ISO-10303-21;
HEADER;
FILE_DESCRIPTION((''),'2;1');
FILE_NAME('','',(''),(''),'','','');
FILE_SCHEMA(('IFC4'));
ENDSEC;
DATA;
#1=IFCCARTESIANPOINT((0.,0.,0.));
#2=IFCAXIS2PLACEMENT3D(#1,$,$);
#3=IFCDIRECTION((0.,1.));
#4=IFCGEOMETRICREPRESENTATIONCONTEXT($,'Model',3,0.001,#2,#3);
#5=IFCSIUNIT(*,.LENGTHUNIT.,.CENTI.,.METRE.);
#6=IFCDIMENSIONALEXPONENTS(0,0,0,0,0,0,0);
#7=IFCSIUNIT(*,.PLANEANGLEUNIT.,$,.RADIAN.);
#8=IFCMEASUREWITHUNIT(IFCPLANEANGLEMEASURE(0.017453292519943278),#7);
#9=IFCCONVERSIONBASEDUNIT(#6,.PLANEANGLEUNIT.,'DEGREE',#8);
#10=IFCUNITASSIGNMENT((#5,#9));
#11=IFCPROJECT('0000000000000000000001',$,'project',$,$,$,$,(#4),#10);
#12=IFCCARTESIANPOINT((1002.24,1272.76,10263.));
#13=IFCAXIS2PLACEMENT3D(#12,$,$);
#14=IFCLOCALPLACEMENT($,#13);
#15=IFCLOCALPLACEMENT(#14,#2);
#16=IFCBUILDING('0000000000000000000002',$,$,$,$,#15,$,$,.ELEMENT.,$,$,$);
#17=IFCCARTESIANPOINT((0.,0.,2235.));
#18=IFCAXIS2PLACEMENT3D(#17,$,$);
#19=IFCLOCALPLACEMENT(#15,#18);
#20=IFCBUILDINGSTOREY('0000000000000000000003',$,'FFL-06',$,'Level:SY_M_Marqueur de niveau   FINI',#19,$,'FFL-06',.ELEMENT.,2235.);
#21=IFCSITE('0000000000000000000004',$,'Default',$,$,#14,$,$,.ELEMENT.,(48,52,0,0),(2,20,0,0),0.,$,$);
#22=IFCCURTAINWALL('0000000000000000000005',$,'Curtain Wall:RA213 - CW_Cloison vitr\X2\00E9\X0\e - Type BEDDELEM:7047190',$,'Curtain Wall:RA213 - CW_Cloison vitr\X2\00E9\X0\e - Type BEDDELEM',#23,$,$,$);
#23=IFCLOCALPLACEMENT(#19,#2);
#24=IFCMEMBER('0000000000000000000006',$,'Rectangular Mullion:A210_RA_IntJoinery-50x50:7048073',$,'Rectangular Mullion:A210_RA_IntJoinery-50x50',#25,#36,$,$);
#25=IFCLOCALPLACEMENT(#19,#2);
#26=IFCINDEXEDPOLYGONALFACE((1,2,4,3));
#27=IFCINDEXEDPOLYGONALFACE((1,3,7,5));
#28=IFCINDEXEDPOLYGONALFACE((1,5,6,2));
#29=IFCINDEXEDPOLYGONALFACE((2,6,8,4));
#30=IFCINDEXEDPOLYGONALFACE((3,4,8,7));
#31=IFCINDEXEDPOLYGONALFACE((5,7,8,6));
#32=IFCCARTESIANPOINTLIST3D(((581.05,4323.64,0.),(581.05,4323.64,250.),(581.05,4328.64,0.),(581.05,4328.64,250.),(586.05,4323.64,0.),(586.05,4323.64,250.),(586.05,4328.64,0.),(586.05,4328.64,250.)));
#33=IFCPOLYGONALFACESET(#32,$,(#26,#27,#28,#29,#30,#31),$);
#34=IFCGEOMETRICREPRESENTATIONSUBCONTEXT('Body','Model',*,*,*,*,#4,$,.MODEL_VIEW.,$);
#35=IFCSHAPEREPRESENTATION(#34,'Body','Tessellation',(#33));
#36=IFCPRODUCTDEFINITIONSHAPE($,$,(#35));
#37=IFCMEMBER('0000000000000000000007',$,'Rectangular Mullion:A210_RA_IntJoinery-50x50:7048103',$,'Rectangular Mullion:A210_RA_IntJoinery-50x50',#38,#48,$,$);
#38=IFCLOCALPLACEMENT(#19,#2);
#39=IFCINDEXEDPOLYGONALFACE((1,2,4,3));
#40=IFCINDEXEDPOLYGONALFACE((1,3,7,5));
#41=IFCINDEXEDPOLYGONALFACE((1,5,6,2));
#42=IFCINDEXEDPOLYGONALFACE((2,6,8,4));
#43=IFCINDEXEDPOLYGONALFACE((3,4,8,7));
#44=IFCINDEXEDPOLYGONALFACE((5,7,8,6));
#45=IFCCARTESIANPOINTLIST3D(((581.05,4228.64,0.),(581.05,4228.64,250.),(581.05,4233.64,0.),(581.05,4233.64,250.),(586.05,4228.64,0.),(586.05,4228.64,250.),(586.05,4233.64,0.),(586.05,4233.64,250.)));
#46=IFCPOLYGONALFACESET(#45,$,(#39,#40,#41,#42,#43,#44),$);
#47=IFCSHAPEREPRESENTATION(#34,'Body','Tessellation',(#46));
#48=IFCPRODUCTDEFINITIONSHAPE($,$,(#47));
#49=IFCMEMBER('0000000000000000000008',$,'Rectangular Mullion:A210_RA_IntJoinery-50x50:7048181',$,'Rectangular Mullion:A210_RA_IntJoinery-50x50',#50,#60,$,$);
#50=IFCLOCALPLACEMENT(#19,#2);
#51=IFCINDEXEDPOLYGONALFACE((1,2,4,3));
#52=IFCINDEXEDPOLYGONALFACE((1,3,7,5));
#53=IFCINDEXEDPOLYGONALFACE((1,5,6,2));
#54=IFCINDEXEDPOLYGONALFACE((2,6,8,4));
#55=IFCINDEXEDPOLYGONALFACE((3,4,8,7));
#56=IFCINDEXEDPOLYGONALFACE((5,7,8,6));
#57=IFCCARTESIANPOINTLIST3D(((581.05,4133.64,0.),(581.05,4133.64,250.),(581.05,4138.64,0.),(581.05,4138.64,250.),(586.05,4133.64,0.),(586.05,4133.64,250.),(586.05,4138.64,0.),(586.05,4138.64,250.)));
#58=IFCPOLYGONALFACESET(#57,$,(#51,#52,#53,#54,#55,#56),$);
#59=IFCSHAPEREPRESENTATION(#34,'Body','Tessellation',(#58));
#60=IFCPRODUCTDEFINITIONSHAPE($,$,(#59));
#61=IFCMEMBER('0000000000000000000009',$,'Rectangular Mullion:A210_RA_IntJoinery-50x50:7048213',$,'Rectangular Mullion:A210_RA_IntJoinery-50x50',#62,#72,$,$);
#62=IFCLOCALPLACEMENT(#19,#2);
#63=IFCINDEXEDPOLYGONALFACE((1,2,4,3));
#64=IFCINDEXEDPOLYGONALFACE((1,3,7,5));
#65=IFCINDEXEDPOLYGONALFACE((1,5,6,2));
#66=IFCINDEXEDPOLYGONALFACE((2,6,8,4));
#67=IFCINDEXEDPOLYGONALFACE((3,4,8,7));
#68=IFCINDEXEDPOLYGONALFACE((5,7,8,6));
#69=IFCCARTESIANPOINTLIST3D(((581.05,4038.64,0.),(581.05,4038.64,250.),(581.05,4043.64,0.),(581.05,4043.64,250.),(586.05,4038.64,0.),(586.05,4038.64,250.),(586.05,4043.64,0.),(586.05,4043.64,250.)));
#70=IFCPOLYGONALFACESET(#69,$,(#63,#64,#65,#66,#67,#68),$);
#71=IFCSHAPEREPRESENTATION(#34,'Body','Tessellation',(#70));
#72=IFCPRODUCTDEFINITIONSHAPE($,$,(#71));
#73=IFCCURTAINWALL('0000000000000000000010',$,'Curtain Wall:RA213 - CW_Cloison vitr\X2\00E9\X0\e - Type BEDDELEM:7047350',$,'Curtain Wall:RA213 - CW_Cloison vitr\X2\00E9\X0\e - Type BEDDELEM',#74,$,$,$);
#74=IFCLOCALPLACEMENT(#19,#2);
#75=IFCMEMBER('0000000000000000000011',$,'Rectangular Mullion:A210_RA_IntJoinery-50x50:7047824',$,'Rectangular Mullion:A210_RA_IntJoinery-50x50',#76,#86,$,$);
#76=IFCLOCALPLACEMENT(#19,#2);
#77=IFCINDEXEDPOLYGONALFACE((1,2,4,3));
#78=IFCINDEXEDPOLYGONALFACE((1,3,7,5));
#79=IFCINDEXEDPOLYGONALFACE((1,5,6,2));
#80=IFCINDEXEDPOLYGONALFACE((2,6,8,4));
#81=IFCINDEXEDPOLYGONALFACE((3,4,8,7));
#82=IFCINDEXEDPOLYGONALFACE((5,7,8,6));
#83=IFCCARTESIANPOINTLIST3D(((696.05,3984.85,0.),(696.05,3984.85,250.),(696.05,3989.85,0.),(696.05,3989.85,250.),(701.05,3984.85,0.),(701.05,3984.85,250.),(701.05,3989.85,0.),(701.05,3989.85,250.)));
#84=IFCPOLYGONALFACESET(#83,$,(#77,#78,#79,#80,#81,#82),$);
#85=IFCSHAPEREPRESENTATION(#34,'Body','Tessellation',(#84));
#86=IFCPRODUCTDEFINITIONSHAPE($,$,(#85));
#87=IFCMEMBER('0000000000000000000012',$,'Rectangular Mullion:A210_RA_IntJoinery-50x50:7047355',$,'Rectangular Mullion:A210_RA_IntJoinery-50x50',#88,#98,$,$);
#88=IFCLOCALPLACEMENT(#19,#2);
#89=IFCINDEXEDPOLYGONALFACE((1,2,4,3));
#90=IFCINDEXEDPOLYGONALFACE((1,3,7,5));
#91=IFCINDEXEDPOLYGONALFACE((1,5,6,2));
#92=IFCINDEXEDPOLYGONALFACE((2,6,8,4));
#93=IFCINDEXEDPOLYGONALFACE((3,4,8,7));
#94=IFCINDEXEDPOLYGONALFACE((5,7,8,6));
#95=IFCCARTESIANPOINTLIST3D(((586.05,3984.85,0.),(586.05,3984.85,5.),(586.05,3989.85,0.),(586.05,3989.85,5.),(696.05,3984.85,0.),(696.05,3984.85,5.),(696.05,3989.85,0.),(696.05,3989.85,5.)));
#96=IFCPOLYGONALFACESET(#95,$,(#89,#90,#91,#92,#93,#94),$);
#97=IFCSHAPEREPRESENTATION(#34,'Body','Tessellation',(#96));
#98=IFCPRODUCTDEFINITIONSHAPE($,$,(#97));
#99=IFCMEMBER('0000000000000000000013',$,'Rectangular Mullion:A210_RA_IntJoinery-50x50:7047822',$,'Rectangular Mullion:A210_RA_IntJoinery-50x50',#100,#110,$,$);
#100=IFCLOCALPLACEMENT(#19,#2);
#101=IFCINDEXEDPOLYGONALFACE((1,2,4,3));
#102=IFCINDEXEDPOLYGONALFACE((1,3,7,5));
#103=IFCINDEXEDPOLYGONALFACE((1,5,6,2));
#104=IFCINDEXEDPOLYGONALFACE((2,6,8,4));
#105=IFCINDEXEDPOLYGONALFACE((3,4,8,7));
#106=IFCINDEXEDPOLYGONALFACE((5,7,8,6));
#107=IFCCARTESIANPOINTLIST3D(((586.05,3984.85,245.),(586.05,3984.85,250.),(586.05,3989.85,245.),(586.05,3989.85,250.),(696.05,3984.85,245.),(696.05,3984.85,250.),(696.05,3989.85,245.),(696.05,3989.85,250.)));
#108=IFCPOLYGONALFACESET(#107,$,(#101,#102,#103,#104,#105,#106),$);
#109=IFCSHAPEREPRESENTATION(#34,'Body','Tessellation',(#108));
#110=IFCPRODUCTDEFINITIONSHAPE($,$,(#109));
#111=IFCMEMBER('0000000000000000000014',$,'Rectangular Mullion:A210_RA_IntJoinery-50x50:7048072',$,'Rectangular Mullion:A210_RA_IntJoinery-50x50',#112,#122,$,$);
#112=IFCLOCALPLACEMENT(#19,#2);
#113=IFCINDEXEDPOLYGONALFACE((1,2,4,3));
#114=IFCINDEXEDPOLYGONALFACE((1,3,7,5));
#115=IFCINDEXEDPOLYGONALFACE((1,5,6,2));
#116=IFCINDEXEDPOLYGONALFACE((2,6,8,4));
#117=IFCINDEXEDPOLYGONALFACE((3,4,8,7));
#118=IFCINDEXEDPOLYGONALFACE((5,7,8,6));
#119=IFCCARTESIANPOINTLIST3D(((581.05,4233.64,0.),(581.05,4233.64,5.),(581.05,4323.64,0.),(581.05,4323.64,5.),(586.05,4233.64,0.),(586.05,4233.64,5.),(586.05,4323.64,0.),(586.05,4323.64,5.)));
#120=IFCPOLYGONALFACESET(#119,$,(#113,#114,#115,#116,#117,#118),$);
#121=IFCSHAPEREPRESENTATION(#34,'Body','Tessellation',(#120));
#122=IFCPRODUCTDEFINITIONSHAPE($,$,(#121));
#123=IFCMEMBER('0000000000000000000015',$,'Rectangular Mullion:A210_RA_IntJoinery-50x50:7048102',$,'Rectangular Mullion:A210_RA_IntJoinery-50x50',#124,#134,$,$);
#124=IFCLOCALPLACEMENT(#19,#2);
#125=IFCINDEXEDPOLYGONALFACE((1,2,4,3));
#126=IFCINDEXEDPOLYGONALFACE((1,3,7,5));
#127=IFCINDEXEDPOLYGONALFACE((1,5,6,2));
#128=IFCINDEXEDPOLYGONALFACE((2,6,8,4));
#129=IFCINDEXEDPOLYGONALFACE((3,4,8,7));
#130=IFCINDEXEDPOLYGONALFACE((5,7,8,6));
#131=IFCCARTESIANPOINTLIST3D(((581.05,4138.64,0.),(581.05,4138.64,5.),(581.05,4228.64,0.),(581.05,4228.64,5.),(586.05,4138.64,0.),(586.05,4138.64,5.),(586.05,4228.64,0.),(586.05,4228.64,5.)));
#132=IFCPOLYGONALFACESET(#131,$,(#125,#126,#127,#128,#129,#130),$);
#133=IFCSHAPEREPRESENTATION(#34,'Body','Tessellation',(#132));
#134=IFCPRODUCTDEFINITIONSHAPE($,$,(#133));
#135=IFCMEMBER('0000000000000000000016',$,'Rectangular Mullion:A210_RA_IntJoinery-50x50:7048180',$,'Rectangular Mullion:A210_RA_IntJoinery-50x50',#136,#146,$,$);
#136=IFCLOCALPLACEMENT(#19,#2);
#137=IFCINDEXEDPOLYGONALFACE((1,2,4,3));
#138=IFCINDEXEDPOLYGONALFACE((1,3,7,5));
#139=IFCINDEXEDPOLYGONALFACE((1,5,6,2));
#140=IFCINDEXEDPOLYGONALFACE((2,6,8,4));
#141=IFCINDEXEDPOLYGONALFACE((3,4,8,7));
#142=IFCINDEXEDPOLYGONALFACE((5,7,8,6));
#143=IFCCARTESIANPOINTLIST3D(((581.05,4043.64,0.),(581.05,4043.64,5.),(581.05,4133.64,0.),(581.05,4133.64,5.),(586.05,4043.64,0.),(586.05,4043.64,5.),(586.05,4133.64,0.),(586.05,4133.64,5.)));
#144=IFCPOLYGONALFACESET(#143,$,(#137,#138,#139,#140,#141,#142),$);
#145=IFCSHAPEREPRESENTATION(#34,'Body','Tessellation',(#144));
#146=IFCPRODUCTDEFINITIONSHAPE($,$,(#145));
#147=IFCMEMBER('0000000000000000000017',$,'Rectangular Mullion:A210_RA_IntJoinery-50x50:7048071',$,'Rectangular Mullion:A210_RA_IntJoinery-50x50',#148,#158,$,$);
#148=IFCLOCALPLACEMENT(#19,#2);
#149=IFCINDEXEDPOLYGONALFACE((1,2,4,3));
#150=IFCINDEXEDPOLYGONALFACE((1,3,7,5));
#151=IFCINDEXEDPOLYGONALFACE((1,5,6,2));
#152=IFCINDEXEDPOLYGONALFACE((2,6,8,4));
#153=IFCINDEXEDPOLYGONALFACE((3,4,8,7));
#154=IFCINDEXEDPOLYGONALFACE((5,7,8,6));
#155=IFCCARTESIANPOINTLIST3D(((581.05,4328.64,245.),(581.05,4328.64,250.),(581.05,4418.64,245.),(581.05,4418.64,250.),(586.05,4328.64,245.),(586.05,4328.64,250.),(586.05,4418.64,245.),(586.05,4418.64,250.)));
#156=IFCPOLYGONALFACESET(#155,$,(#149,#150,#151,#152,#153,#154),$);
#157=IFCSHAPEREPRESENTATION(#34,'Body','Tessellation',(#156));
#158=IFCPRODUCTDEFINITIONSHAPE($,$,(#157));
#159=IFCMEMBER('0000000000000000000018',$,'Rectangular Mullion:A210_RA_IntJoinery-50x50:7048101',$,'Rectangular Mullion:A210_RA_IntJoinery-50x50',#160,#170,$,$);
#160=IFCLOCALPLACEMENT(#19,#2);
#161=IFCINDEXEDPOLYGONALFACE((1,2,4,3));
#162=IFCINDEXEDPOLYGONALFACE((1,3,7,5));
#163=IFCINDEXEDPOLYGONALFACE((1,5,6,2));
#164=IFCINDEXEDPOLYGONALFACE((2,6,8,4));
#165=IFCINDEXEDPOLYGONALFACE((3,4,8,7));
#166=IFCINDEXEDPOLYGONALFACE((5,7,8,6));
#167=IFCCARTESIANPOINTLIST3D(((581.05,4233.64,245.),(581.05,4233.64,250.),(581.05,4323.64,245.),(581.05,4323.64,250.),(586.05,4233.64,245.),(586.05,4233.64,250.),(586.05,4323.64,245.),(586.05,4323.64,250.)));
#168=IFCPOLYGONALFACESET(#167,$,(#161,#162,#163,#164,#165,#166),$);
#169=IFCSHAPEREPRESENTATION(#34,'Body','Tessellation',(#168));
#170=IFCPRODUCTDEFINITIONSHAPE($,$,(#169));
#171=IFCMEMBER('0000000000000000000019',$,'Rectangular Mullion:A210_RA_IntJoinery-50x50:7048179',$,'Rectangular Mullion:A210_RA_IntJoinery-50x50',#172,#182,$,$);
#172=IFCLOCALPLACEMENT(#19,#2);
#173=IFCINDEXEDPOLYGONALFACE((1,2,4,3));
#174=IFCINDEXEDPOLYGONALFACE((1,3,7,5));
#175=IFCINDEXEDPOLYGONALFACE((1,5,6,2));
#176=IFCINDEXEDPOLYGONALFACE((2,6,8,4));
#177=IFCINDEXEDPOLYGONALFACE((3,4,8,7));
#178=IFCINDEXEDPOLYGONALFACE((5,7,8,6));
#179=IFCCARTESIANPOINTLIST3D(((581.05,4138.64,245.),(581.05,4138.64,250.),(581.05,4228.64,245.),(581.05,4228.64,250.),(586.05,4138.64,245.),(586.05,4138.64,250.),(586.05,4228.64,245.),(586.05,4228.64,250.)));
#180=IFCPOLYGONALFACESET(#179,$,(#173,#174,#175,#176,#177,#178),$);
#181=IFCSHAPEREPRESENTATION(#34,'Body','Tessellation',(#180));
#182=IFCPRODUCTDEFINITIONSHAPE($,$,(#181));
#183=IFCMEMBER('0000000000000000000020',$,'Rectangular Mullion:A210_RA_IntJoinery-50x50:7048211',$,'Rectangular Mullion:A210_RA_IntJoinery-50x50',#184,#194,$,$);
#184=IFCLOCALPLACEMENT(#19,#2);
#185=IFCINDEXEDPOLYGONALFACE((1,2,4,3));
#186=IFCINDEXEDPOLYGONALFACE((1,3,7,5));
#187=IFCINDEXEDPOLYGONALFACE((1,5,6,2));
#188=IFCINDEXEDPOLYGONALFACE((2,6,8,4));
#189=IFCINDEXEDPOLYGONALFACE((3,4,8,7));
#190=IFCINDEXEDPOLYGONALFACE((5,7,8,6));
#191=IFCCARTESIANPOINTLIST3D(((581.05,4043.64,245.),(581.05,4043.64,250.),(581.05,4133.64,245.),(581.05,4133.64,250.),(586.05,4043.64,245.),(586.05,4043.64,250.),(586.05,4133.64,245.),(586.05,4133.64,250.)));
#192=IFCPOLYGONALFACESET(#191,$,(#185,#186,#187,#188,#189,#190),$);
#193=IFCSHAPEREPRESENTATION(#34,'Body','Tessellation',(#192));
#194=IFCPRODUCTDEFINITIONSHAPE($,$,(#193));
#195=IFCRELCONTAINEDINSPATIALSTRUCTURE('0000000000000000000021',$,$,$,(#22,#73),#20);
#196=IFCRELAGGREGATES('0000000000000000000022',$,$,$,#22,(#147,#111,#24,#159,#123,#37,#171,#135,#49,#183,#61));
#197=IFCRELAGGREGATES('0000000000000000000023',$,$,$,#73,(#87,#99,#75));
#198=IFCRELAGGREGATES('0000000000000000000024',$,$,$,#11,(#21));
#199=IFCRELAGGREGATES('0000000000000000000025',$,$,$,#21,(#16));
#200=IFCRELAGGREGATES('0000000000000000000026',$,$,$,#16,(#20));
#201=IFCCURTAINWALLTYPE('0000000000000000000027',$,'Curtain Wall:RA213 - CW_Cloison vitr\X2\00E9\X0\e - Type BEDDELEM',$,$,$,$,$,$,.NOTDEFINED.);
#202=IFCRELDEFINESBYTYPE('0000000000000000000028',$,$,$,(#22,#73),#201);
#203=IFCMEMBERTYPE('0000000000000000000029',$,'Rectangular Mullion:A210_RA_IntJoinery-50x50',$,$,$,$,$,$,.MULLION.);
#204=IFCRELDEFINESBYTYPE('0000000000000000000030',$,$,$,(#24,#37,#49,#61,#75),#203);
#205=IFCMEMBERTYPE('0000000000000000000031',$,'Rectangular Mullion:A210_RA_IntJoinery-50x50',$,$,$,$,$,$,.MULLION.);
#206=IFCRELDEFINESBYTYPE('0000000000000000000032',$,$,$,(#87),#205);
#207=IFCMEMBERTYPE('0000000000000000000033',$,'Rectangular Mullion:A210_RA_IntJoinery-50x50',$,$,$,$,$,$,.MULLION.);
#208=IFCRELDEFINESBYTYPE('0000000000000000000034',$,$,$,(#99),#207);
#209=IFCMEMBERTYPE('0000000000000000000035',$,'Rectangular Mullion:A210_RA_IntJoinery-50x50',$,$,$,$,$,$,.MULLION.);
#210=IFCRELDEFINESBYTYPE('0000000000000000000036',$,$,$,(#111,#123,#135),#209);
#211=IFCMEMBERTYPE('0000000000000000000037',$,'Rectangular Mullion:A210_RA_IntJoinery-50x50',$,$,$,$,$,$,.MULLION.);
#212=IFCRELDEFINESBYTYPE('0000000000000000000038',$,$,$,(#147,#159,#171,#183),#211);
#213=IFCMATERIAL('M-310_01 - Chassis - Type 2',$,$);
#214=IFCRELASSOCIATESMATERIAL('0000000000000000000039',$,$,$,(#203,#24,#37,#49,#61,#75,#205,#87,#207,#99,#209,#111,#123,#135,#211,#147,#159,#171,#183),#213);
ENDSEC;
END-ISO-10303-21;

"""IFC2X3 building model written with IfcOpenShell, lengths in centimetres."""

from ifc_helpers import new_model, entity, si_unit, converted_unit, direction, frame, origin, origin_2d_with_axis, place, context, subcontext, project, spatial, rectangle, extrude, source, transform, mapped, material, type_object, type_shapes, element, aggregate, save


model = new_model("IFC2X3")

# Units and contexts
model_context = context("Model", 3, precision=0.001, world=origin(), true_north=direction((0.0, 1.0)))
body_context = subcontext(model_context, "Body", "Model", "MODEL_VIEW")
ifc_project = project(units=[si_unit("LENGTHUNIT", "METRE", prefix="CENTI"), converted_unit("PLANEANGLEUNIT", "DEGREE", entity("IfcPlaneAngleMeasure", 0.017453292519943278), si_unit("PLANEANGLEUNIT", "RADIAN"), dimensions=[0, 0, 0, 0, 0, 0, 0])], contexts=[model_context])

# Site, building, storey
site_placement = place(None, frame((1002.24, 1272.76, 10263.0)))
site = spatial("IfcSite", under=ifc_project, at=site_placement, Name="Default", CompositionType="ELEMENT", RefLatitude=(48, 52, 0, 0), RefLongitude=(2, 20, 0, 0), RefElevation=0.0)
building_placement = place(site_placement, origin())
building = spatial("IfcBuilding", under=site, at=building_placement, CompositionType="ELEMENT")
storey_placement = place(building_placement, frame((0.0, 0.0, 2235.0)))
storey = spatial("IfcBuildingStorey", under=building, at=storey_placement, Name="FFL-06", ObjectType="Level:SY_M_Marqueur de niveau   FINI", LongName="FFL-06", CompositionType="ELEMENT", Elevation=2235.0)

# Curtain walls, members
curtain_wall_type_1 = type_object("IfcCurtainWallType", Name="Curtain Wall:RA213 - CW_Cloison vitrée - Type BEDDELEM", PredefinedType="NOTDEFINED")
curtain_wall_1_placement = place(storey_placement, frame((0.0, 0.0, -2235.0)))
curtain_wall_1 = element("IfcCurtainWall", 1, at=curtain_wall_1_placement, inside=storey, type_object=curtain_wall_type_1, Name="Curtain Wall:RA213 - CW_Cloison vitrée - Type BEDDELEM:7047190", ObjectType="Curtain Wall:RA213 - CW_Cloison vitrée - Type BEDDELEM")
ifc_material_1 = material(Name="M-310_01 - Chassis - Type 2")
member_type_1 = type_object("IfcMemberType", Name="Rectangular Mullion:A210_RA_IntJoinery-50x50", PredefinedType="MULLION", material=ifc_material_1)
shared_shape_1 = source(origin(), body_context, "Body", "SweptSolid", [
    extrude(rectangle(XDim=5.0, YDim=5.0, at=origin_2d_with_axis()), frame((0.0, -2.5, -250.0), z_axis=(0.0, 0.0, 1.0), x_axis=(-1.0, 0.0, 0.0)), (0.0, 0.0, 1.0), 250.0),
])
type_shapes(member_type_1, [shared_shape_1])
member_1_placement = place(curtain_wall_1_placement, frame((581.05, 4326.14, 2235.0), z_axis=(0.0, 0.0, -1.0), x_axis=(0.0, -1.0, 0.0)))
member_1 = element("IfcMember", 2, at=member_1_placement, type_object=member_type_1, material=ifc_material_1, Name="Rectangular Mullion:A210_RA_IntJoinery-50x50:7048073", ObjectType="Rectangular Mullion:A210_RA_IntJoinery-50x50", context=body_context, shape_type="MappedRepresentation", body=[
    mapped(shared_shape_1, transform((0.0, 0.0, 0.0), scale=1.0)),
])
member_2_placement = place(curtain_wall_1_placement, frame((581.05, 4231.14, 2235.0), z_axis=(0.0, 0.0, -1.0), x_axis=(0.0, -1.0, 0.0)))
member_2 = element("IfcMember", 3, at=member_2_placement, type_object=member_type_1, material=ifc_material_1, Name="Rectangular Mullion:A210_RA_IntJoinery-50x50:7048103", ObjectType="Rectangular Mullion:A210_RA_IntJoinery-50x50", context=body_context, shape_type="MappedRepresentation", body=[
    mapped(shared_shape_1, transform((0.0, 0.0, 0.0), scale=1.0)),
])
member_3_placement = place(curtain_wall_1_placement, frame((581.05, 4136.14, 2235.0), z_axis=(0.0, 0.0, -1.0), x_axis=(0.0, -1.0, 0.0)))
member_3 = element("IfcMember", 4, at=member_3_placement, type_object=member_type_1, material=ifc_material_1, Name="Rectangular Mullion:A210_RA_IntJoinery-50x50:7048181", ObjectType="Rectangular Mullion:A210_RA_IntJoinery-50x50", context=body_context, shape_type="MappedRepresentation", body=[
    mapped(shared_shape_1, transform((0.0, 0.0, 0.0), scale=1.0)),
])
member_4_placement = place(curtain_wall_1_placement, frame((581.05, 4041.14, 2235.0), z_axis=(0.0, 0.0, -1.0), x_axis=(0.0, -1.0, 0.0)))
member_4 = element("IfcMember", 5, at=member_4_placement, type_object=member_type_1, material=ifc_material_1, Name="Rectangular Mullion:A210_RA_IntJoinery-50x50:7048213", ObjectType="Rectangular Mullion:A210_RA_IntJoinery-50x50", context=body_context, shape_type="MappedRepresentation", body=[
    mapped(shared_shape_1, transform((0.0, 0.0, 0.0), scale=1.0)),
])
curtain_wall_2_placement = place(storey_placement, frame((0.0, 0.0, -2235.0)))
curtain_wall_2 = element("IfcCurtainWall", 6, at=curtain_wall_2_placement, inside=storey, type_object=curtain_wall_type_1, Name="Curtain Wall:RA213 - CW_Cloison vitrée - Type BEDDELEM:7047350", ObjectType="Curtain Wall:RA213 - CW_Cloison vitrée - Type BEDDELEM")
member_5_placement = place(curtain_wall_2_placement, frame((698.55, 3984.85, 2235.0), z_axis=(0.0, 0.0, -1.0), x_axis=(1.0, 0.0, 0.0)))
member_5 = element("IfcMember", 7, at=member_5_placement, type_object=member_type_1, material=ifc_material_1, Name="Rectangular Mullion:A210_RA_IntJoinery-50x50:7047824", ObjectType="Rectangular Mullion:A210_RA_IntJoinery-50x50", context=body_context, shape_type="MappedRepresentation", body=[
    mapped(shared_shape_1, transform((0.0, 0.0, 0.0), scale=1.0)),
])
member_type_2 = type_object("IfcMemberType", Name="Rectangular Mullion:A210_RA_IntJoinery-50x50", PredefinedType="MULLION", material=ifc_material_1)
shared_shape_2 = source(origin(), body_context, "Body", "SweptSolid", [
    extrude(rectangle(XDim=5.0, YDim=5.0, at=origin_2d_with_axis()), frame((-2.5, -2.5, -110.0), z_axis=(0.0, 0.0, 1.0), x_axis=(-1.0, 0.0, 0.0)), (0.0, 0.0, 1.0), 110.0),
])
type_shapes(member_type_2, [shared_shape_2])
member_6_placement = place(curtain_wall_2_placement, frame((586.05, 3984.85, 2235.0), z_axis=(-1.0, 0.0, 0.0), x_axis=(0.0, 0.0, -1.0)))
member_6 = element("IfcMember", 8, at=member_6_placement, type_object=member_type_2, material=ifc_material_1, Name="Rectangular Mullion:A210_RA_IntJoinery-50x50:7047355", ObjectType="Rectangular Mullion:A210_RA_IntJoinery-50x50", context=body_context, shape_type="MappedRepresentation", body=[
    mapped(shared_shape_2, transform((0.0, 0.0, 0.0), scale=1.0)),
])
member_type_3 = type_object("IfcMemberType", Name="Rectangular Mullion:A210_RA_IntJoinery-50x50", PredefinedType="MULLION", material=ifc_material_1)
shared_shape_3 = source(origin(), body_context, "Body", "SweptSolid", [
    extrude(rectangle(XDim=5.0, YDim=5.0, at=origin_2d_with_axis()), frame((-2.5, -2.5, -110.0), z_axis=(0.0, 0.0, 1.0), x_axis=(-1.0, 0.0, 0.0)), (0.0, 0.0, 1.0), 110.0),
])
type_shapes(member_type_3, [shared_shape_3])
member_7_placement = place(curtain_wall_2_placement, frame((696.05, 3984.85, 2485.0), z_axis=(1.0, 0.0, 0.0), x_axis=(0.0, 0.0, 1.0)))
member_7 = element("IfcMember", 9, at=member_7_placement, type_object=member_type_3, material=ifc_material_1, Name="Rectangular Mullion:A210_RA_IntJoinery-50x50:7047822", ObjectType="Rectangular Mullion:A210_RA_IntJoinery-50x50", context=body_context, shape_type="MappedRepresentation", body=[
    mapped(shared_shape_3, transform((0.0, 0.0, 0.0), scale=1.0)),
])

# Members
member_type_4 = type_object("IfcMemberType", Name="Rectangular Mullion:A210_RA_IntJoinery-50x50", PredefinedType="MULLION", material=ifc_material_1)
shared_shape_4 = source(origin(), body_context, "Body", "SweptSolid", [
    extrude(rectangle(XDim=5.0, YDim=5.0, at=origin_2d_with_axis()), frame((-2.5, -2.5, -90.0), z_axis=(0.0, 0.0, 1.0), x_axis=(-1.0, 0.0, 0.0)), (0.0, 0.0, 1.0), 90.0),
])
type_shapes(member_type_4, [shared_shape_4])
member_8_placement = place(curtain_wall_1_placement, frame((581.05, 4323.64, 2235.0), z_axis=(0.0, 1.0, 0.0), x_axis=(0.0, 0.0, -1.0)))
member_8 = element("IfcMember", 10, at=member_8_placement, type_object=member_type_4, material=ifc_material_1, Name="Rectangular Mullion:A210_RA_IntJoinery-50x50:7048072", ObjectType="Rectangular Mullion:A210_RA_IntJoinery-50x50", context=body_context, shape_type="MappedRepresentation", body=[
    mapped(shared_shape_4, transform((0.0, 0.0, 0.0), scale=1.0)),
])
member_9_placement = place(curtain_wall_1_placement, frame((581.05, 4228.64, 2235.0), z_axis=(0.0, 1.0, 0.0), x_axis=(0.0, 0.0, -1.0)))
member_9 = element("IfcMember", 11, at=member_9_placement, type_object=member_type_4, material=ifc_material_1, Name="Rectangular Mullion:A210_RA_IntJoinery-50x50:7048102", ObjectType="Rectangular Mullion:A210_RA_IntJoinery-50x50", context=body_context, shape_type="MappedRepresentation", body=[
    mapped(shared_shape_4, transform((0.0, 0.0, 0.0), scale=1.0)),
])
member_10_placement = place(curtain_wall_1_placement, frame((581.05, 4133.64, 2235.0), z_axis=(0.0, 1.0, 0.0), x_axis=(0.0, 0.0, -1.0)))
member_10 = element("IfcMember", 12, at=member_10_placement, type_object=member_type_4, material=ifc_material_1, Name="Rectangular Mullion:A210_RA_IntJoinery-50x50:7048180", ObjectType="Rectangular Mullion:A210_RA_IntJoinery-50x50", context=body_context, shape_type="MappedRepresentation", body=[
    mapped(shared_shape_4, transform((0.0, 0.0, 0.0), scale=1.0)),
])
member_type_5 = type_object("IfcMemberType", Name="Rectangular Mullion:A210_RA_IntJoinery-50x50", PredefinedType="MULLION", material=ifc_material_1)
shared_shape_5 = source(origin(), body_context, "Body", "SweptSolid", [
    extrude(rectangle(XDim=5.0, YDim=5.0, at=origin_2d_with_axis()), frame((-2.5, -2.5, -90.0), z_axis=(0.0, 0.0, 1.0), x_axis=(-1.0, 0.0, 0.0)), (0.0, 0.0, 1.0), 90.0),
])
type_shapes(member_type_5, [shared_shape_5])
member_11_placement = place(curtain_wall_1_placement, frame((581.05, 4328.64, 2485.0), z_axis=(0.0, -1.0, 0.0), x_axis=(0.0, 0.0, 1.0)))
member_11 = element("IfcMember", 13, at=member_11_placement, type_object=member_type_5, material=ifc_material_1, Name="Rectangular Mullion:A210_RA_IntJoinery-50x50:7048071", ObjectType="Rectangular Mullion:A210_RA_IntJoinery-50x50", context=body_context, shape_type="MappedRepresentation", body=[
    mapped(shared_shape_5, transform((0.0, 0.0, 0.0), scale=1.0)),
])
member_12_placement = place(curtain_wall_1_placement, frame((581.05, 4233.64, 2485.0), z_axis=(0.0, -1.0, 0.0), x_axis=(0.0, 0.0, 1.0)))
member_12 = element("IfcMember", 14, at=member_12_placement, type_object=member_type_5, material=ifc_material_1, Name="Rectangular Mullion:A210_RA_IntJoinery-50x50:7048101", ObjectType="Rectangular Mullion:A210_RA_IntJoinery-50x50", context=body_context, shape_type="MappedRepresentation", body=[
    mapped(shared_shape_5, transform((0.0, 0.0, 0.0), scale=1.0)),
])
member_13_placement = place(curtain_wall_1_placement, frame((581.05, 4138.64, 2485.0), z_axis=(0.0, -1.0, 0.0), x_axis=(0.0, 0.0, 1.0)))
member_13 = element("IfcMember", 15, at=member_13_placement, type_object=member_type_5, material=ifc_material_1, Name="Rectangular Mullion:A210_RA_IntJoinery-50x50:7048179", ObjectType="Rectangular Mullion:A210_RA_IntJoinery-50x50", context=body_context, shape_type="MappedRepresentation", body=[
    mapped(shared_shape_5, transform((0.0, 0.0, 0.0), scale=1.0)),
])
member_14_placement = place(curtain_wall_1_placement, frame((581.05, 4043.64, 2485.0), z_axis=(0.0, -1.0, 0.0), x_axis=(0.0, 0.0, 1.0)))
member_14 = element("IfcMember", 16, at=member_14_placement, type_object=member_type_5, material=ifc_material_1, Name="Rectangular Mullion:A210_RA_IntJoinery-50x50:7048211", ObjectType="Rectangular Mullion:A210_RA_IntJoinery-50x50", context=body_context, shape_type="MappedRepresentation", body=[
    mapped(shared_shape_5, transform((0.0, 0.0, 0.0), scale=1.0)),
])

aggregate(curtain_wall_1, [member_11, member_8, member_1, member_12, member_9, member_2, member_13, member_10, member_3, member_14, member_4])

aggregate(curtain_wall_2, [member_6, member_7, member_5])

save(model, "model.ifc")
